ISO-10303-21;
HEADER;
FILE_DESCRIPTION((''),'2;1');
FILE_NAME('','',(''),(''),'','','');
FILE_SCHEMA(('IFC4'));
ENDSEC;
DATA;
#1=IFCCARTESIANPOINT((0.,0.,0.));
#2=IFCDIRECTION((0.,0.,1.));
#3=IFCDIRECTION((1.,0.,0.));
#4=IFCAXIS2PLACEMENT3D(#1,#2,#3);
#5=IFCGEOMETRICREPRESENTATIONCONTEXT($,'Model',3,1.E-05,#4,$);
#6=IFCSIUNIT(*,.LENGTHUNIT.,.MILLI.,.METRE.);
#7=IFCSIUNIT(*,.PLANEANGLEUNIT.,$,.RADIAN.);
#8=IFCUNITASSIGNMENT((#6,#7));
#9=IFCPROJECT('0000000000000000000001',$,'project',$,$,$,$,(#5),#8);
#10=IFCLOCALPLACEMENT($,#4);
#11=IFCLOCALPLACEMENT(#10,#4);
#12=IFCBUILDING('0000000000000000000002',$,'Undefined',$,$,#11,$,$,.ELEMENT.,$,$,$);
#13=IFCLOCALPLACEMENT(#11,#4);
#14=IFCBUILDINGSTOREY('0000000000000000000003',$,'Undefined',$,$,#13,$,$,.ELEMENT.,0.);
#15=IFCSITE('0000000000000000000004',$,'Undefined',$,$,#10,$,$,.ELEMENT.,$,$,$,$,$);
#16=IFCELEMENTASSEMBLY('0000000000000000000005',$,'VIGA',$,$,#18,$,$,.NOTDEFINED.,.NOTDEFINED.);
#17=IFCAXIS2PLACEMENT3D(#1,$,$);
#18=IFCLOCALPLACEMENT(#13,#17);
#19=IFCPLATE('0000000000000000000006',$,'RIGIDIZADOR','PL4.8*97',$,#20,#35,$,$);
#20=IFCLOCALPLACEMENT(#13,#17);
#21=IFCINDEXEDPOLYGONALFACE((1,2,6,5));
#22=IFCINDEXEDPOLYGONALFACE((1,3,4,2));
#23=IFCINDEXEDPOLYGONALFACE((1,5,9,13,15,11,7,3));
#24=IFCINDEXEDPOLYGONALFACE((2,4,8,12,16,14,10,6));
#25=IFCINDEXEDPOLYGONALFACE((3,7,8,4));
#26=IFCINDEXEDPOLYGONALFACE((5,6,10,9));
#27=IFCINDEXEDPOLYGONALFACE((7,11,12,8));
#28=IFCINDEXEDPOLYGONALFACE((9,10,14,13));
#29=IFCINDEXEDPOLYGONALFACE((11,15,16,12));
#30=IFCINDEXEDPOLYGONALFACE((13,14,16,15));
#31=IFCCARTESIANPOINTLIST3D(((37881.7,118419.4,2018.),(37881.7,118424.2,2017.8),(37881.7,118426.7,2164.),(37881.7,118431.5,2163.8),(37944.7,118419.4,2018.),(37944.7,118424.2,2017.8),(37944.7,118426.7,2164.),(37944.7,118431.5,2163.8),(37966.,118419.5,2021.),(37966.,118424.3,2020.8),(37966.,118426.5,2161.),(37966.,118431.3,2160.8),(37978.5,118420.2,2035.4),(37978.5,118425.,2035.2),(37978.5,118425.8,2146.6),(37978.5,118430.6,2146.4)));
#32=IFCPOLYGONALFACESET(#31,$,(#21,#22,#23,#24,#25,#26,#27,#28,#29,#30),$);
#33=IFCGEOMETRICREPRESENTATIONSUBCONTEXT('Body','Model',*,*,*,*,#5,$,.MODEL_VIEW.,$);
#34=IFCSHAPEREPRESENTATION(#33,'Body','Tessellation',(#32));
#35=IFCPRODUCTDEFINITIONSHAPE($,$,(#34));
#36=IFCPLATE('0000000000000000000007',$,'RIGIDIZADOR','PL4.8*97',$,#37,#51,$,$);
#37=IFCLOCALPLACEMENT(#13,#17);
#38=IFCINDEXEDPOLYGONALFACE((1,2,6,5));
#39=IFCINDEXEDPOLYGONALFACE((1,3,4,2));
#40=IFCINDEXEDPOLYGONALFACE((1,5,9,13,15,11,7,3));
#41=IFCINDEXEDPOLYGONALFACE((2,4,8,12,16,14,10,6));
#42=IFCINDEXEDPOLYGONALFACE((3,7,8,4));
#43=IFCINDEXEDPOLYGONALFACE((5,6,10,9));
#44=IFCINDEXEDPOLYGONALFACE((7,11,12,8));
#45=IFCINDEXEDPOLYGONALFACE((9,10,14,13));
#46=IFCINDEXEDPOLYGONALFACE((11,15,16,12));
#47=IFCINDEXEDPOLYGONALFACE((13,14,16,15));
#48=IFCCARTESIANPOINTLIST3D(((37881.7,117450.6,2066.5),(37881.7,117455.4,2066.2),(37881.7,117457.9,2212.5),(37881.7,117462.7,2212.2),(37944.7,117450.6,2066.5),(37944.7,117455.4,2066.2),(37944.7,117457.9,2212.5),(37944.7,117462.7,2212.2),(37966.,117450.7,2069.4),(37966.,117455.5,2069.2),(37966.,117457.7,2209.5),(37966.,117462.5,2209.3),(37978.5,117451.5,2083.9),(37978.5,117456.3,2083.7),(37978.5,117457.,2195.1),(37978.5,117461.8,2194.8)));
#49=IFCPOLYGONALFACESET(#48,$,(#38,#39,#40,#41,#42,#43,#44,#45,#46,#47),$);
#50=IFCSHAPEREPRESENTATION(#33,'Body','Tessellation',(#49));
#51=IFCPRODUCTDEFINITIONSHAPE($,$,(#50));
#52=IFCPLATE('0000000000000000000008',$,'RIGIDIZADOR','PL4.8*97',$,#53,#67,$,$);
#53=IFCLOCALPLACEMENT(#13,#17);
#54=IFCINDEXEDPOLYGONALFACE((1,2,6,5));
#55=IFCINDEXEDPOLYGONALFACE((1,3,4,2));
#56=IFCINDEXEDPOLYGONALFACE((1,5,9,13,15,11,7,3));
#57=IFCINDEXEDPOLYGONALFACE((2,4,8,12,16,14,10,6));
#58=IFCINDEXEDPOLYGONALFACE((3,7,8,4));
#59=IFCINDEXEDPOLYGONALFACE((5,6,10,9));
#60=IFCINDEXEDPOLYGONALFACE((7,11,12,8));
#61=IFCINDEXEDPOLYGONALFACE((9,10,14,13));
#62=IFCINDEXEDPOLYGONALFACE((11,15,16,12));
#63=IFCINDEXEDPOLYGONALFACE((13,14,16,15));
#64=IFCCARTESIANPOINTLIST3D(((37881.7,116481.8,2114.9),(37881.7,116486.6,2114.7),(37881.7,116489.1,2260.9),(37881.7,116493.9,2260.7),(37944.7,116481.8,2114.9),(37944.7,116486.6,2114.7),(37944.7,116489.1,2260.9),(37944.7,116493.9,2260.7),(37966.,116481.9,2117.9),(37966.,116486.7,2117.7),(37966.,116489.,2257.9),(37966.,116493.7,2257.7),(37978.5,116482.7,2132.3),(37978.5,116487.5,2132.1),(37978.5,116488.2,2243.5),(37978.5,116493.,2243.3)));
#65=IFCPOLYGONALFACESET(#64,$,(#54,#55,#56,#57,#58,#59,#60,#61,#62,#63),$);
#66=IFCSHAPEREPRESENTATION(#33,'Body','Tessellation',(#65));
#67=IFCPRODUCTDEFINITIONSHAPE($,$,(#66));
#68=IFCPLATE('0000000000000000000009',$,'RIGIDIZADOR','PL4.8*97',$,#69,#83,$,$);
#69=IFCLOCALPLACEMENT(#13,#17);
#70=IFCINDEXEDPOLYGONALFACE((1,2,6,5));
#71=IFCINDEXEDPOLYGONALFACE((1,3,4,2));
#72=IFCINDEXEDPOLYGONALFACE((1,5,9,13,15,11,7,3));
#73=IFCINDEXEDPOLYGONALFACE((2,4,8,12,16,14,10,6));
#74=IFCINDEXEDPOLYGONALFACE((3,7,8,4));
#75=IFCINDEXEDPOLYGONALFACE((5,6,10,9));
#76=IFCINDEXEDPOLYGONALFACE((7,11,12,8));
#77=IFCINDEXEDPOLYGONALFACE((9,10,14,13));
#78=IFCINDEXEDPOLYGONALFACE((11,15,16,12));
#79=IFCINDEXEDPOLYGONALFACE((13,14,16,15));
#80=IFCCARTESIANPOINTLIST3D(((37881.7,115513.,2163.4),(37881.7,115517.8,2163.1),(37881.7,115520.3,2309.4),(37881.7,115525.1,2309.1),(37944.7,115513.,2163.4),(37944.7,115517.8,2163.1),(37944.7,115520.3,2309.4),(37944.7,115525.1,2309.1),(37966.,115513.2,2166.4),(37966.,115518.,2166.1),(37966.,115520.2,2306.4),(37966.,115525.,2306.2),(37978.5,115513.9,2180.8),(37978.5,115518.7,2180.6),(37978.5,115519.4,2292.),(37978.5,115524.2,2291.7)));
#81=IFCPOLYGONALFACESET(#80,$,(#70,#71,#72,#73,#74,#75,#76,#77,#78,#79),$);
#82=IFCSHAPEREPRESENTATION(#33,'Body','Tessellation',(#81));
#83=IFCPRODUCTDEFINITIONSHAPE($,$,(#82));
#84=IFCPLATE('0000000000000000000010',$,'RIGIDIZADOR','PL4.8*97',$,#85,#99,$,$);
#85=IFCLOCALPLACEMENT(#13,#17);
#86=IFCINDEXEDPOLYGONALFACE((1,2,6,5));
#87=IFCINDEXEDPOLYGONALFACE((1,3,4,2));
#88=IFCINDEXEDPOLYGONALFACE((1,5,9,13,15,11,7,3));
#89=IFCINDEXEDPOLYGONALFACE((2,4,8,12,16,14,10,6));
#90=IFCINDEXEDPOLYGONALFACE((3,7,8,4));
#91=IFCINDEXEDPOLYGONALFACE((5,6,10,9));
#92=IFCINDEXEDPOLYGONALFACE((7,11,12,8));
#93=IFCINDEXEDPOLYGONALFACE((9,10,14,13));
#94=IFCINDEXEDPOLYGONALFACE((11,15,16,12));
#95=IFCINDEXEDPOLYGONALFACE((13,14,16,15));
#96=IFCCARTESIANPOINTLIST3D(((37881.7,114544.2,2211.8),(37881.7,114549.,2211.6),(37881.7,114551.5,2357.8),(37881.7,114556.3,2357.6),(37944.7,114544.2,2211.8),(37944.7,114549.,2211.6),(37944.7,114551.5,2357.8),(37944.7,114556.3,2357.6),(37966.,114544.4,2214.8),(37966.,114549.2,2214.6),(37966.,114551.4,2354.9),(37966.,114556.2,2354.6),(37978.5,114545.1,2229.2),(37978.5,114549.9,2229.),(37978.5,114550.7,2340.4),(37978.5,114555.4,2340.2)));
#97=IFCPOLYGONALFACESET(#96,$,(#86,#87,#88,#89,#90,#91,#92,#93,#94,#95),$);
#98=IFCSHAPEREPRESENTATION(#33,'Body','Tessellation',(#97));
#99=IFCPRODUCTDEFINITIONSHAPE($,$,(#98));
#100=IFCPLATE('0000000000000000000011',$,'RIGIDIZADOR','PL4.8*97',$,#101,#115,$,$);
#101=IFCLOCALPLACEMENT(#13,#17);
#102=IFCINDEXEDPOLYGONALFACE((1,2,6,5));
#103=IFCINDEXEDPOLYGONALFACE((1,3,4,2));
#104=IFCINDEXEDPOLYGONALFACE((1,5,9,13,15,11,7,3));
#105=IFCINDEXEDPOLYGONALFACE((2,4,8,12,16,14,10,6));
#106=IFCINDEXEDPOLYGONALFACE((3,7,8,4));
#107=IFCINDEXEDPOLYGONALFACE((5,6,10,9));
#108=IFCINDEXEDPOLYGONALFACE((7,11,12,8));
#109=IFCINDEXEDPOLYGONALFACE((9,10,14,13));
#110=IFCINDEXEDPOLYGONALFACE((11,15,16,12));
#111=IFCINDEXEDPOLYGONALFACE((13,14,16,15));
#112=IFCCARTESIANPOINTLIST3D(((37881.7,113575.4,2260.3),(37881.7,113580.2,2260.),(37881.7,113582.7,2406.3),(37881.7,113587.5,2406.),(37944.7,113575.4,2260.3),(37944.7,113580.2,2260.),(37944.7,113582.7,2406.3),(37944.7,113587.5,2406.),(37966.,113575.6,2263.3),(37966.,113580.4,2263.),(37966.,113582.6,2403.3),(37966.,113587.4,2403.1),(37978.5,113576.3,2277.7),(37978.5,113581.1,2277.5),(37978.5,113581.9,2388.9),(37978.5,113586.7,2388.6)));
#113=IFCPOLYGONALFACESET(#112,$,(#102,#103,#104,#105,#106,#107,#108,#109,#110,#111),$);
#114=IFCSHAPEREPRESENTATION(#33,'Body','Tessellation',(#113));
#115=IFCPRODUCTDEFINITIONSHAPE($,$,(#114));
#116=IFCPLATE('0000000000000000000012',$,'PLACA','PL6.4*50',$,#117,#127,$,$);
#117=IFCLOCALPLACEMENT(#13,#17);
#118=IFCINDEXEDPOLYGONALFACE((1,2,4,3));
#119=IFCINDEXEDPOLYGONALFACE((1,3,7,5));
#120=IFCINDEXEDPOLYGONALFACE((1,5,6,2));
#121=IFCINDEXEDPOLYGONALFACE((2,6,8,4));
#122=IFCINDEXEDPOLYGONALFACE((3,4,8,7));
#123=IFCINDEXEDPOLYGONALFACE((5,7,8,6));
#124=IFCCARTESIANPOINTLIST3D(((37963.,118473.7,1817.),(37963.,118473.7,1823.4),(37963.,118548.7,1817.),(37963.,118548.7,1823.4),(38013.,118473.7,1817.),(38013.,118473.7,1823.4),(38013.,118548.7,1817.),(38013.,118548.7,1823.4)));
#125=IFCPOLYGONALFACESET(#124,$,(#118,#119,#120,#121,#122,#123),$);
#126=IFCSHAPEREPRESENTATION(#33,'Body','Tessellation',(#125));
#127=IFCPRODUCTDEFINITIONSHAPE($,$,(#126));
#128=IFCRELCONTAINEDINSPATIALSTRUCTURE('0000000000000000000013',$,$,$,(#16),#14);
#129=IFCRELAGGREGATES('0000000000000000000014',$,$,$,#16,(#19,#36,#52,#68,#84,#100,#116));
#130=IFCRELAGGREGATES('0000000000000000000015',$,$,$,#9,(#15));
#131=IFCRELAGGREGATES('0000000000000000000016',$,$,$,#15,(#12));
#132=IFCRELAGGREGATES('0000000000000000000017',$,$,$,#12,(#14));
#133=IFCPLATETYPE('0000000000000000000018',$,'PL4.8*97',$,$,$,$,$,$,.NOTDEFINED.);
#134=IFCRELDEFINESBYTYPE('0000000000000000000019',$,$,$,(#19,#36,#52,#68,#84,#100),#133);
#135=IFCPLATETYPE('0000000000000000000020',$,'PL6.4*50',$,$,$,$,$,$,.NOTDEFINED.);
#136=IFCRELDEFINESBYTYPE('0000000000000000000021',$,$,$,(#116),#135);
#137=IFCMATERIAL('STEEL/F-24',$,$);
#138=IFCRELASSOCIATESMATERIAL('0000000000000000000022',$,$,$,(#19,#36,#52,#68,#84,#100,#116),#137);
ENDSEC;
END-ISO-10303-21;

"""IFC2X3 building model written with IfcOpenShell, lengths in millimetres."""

from ifc_helpers import new_model, si_unit, frame, origin_with_axes, place, context, subcontext, project, spatial, polyline, outline, extrude, material, type_object, element, aggregate, save


model = new_model("IFC2X3")

# Units and contexts
model_context = context("Model", 3, precision=1e-05, world=origin_with_axes())
body_context = subcontext(model_context, "Body", "Model", "MODEL_VIEW")
ifc_project = project(units=[si_unit("LENGTHUNIT", "METRE", prefix="MILLI"), si_unit("PLANEANGLEUNIT", "RADIAN")], contexts=[model_context])

# Site, building, storey
site_placement = place(None, origin_with_axes())
site = spatial("IfcSite", under=ifc_project, at=site_placement, Name="Undefined", CompositionType="ELEMENT")
building_placement = place(site_placement, origin_with_axes())
building = spatial("IfcBuilding", under=site, at=building_placement, Name="Undefined", CompositionType="ELEMENT")
storey_placement = place(building_placement, origin_with_axes())
storey = spatial("IfcBuildingStorey", under=building, at=storey_placement, Name="Undefined", CompositionType="ELEMENT", Elevation=0.0)

# Element assembly
assembly_1_placement = place(storey_placement, origin_with_axes())
assembly_1 = element("IfcElementAssembly", 1, at=assembly_1_placement, inside=storey, Name="VIGA", AssemblyPlace="NOTDEFINED", PredefinedType="NOTDEFINED")
ifc_material_1 = material(Name="STEEL/F-24")

# Plates
plate_type_1 = type_object("IfcPlateType", Name="PL4.8*97", PredefinedType="NOTDEFINED")
plate_1_placement = place(assembly_1_placement, frame((37881.7, 118429.1, 2163.9), z_axis=(0.0, 0.998752, -0.04995), x_axis=(1.0, 0.0, 0.0)))
plate_1 = element("IfcPlate", 2, at=plate_1_placement, type_object=plate_type_1, material=ifc_material_1, Name="RIGIDIZADOR", Description="PL4.8*97", context=body_context, shape_type="SweptSolid", body=[
    extrude(outline(polyline([(0.0, 0.0), (63.0, 0.0), (84.3, 3.0), (96.8, 17.4), (96.8, 128.7), (84.3, 143.2), (63.0, 146.2), (0.0, 146.2), (0.0, 0.0)])), frame((0.0, 0.0, -2.4), z_axis=(0.0, 0.0, 1.0), x_axis=(1.0, 0.0, 0.0)), (0.0, 0.0, 1.0), 4.8),
])
plate_2_placement = place(assembly_1_placement, frame((37881.7, 117460.3, 2212.4), z_axis=(0.0, 0.998752, -0.04995), x_axis=(1.0, 0.0, 0.0)))
plate_2 = element("IfcPlate", 3, at=plate_2_placement, type_object=plate_type_1, material=ifc_material_1, Name="RIGIDIZADOR", Description="PL4.8*97", context=body_context, shape_type="SweptSolid", body=[
    extrude(outline(polyline([(0.0, 0.0), (63.0, 0.0), (84.3, 3.0), (96.8, 17.4), (96.8, 128.7), (84.3, 143.2), (63.0, 146.2), (0.0, 146.2), (0.0, 0.0)])), frame((0.0, 0.0, -2.4), z_axis=(0.0, 0.0, 1.0), x_axis=(1.0, 0.0, 0.0)), (0.0, 0.0, 1.0), 4.8),
])
plate_3_placement = place(assembly_1_placement, frame((37881.7, 116491.5, 2260.8), z_axis=(0.0, 0.998752, -0.04995), x_axis=(1.0, 0.0, 0.0)))
plate_3 = element("IfcPlate", 4, at=plate_3_placement, type_object=plate_type_1, material=ifc_material_1, Name="RIGIDIZADOR", Description="PL4.8*97", context=body_context, shape_type="SweptSolid", body=[
    extrude(outline(polyline([(0.0, 0.0), (63.0, 0.0), (84.3, 3.0), (96.8, 17.4), (96.8, 128.7), (84.3, 143.2), (63.0, 146.2), (0.0, 146.2), (0.0, 0.0)])), frame((0.0, 0.0, -2.4), z_axis=(0.0, 0.0, 1.0), x_axis=(1.0, 0.0, 0.0)), (0.0, 0.0, 1.0), 4.8),
])
plate_4_placement = place(assembly_1_placement, frame((37881.7, 115522.7, 2309.3), z_axis=(0.0, 0.998752, -0.04995), x_axis=(1.0, 0.0, 0.0)))
plate_4 = element("IfcPlate", 5, at=plate_4_placement, type_object=plate_type_1, material=ifc_material_1, Name="RIGIDIZADOR", Description="PL4.8*97", context=body_context, shape_type="SweptSolid", body=[
    extrude(outline(polyline([(0.0, 0.0), (63.0, 0.0), (84.3, 3.0), (96.8, 17.4), (96.8, 128.7), (84.3, 143.2), (63.0, 146.2), (0.0, 146.2), (0.0, 0.0)])), frame((0.0, 0.0, -2.4), z_axis=(0.0, 0.0, 1.0), x_axis=(1.0, 0.0, 0.0)), (0.0, 0.0, 1.0), 4.8),
])
plate_5_placement = place(assembly_1_placement, frame((37881.7, 114553.9, 2357.7), z_axis=(0.0, 0.998752, -0.04995), x_axis=(1.0, 0.0, 0.0)))
plate_5 = element("IfcPlate", 6, at=plate_5_placement, type_object=plate_type_1, material=ifc_material_1, Name="RIGIDIZADOR", Description="PL4.8*97", context=body_context, shape_type="SweptSolid", body=[
    extrude(outline(polyline([(0.0, 0.0), (63.0, 0.0), (84.3, 3.0), (96.8, 17.4), (96.8, 128.7), (84.3, 143.2), (63.0, 146.2), (0.0, 146.2), (0.0, 0.0)])), frame((0.0, 0.0, -2.4), z_axis=(0.0, 0.0, 1.0), x_axis=(1.0, 0.0, 0.0)), (0.0, 0.0, 1.0), 4.8),
])
plate_6_placement = place(assembly_1_placement, frame((37881.7, 113585.1, 2406.2), z_axis=(0.0, 0.998752, -0.04995), x_axis=(1.0, 0.0, 0.0)))
plate_6 = element("IfcPlate", 7, at=plate_6_placement, type_object=plate_type_1, material=ifc_material_1, Name="RIGIDIZADOR", Description="PL4.8*97", context=body_context, shape_type="SweptSolid", body=[
    extrude(outline(polyline([(0.0, 0.0), (63.0, 0.0), (84.3, 3.0), (96.8, 17.4), (96.8, 128.7), (84.3, 143.2), (63.0, 146.2), (0.0, 146.2), (0.0, 0.0)])), frame((0.0, 0.0, -2.4), z_axis=(0.0, 0.0, 1.0), x_axis=(1.0, 0.0, 0.0)), (0.0, 0.0, 1.0), 4.8),
])
plate_type_2 = type_object("IfcPlateType", Name="PL6.4*50", PredefinedType="NOTDEFINED")
plate_7_placement = place(assembly_1_placement, frame((37963.0, 118473.7, 1820.2), z_axis=(0.0, 0.0, -1.0), x_axis=(0.0, 1.0, 0.0)))
plate_7 = element("IfcPlate", 8, at=plate_7_placement, type_object=plate_type_2, material=ifc_material_1, Name="PLACA", Description="PL6.4*50", context=body_context, shape_type="SweptSolid", body=[
    extrude(outline(polyline([(0.0, 0.0), (75.0, 0.0), (75.0, 50.0), (0.0, 50.0), (0.0, 0.0)])), frame((0.0, 0.0, -3.2), z_axis=(0.0, 0.0, 1.0), x_axis=(1.0, 0.0, 0.0)), (0.0, 0.0, 1.0), 6.4),
])

aggregate(assembly_1, [plate_1, plate_2, plate_3, plate_4, plate_5, plate_6, plate_7])

save(model, "model.ifc")
